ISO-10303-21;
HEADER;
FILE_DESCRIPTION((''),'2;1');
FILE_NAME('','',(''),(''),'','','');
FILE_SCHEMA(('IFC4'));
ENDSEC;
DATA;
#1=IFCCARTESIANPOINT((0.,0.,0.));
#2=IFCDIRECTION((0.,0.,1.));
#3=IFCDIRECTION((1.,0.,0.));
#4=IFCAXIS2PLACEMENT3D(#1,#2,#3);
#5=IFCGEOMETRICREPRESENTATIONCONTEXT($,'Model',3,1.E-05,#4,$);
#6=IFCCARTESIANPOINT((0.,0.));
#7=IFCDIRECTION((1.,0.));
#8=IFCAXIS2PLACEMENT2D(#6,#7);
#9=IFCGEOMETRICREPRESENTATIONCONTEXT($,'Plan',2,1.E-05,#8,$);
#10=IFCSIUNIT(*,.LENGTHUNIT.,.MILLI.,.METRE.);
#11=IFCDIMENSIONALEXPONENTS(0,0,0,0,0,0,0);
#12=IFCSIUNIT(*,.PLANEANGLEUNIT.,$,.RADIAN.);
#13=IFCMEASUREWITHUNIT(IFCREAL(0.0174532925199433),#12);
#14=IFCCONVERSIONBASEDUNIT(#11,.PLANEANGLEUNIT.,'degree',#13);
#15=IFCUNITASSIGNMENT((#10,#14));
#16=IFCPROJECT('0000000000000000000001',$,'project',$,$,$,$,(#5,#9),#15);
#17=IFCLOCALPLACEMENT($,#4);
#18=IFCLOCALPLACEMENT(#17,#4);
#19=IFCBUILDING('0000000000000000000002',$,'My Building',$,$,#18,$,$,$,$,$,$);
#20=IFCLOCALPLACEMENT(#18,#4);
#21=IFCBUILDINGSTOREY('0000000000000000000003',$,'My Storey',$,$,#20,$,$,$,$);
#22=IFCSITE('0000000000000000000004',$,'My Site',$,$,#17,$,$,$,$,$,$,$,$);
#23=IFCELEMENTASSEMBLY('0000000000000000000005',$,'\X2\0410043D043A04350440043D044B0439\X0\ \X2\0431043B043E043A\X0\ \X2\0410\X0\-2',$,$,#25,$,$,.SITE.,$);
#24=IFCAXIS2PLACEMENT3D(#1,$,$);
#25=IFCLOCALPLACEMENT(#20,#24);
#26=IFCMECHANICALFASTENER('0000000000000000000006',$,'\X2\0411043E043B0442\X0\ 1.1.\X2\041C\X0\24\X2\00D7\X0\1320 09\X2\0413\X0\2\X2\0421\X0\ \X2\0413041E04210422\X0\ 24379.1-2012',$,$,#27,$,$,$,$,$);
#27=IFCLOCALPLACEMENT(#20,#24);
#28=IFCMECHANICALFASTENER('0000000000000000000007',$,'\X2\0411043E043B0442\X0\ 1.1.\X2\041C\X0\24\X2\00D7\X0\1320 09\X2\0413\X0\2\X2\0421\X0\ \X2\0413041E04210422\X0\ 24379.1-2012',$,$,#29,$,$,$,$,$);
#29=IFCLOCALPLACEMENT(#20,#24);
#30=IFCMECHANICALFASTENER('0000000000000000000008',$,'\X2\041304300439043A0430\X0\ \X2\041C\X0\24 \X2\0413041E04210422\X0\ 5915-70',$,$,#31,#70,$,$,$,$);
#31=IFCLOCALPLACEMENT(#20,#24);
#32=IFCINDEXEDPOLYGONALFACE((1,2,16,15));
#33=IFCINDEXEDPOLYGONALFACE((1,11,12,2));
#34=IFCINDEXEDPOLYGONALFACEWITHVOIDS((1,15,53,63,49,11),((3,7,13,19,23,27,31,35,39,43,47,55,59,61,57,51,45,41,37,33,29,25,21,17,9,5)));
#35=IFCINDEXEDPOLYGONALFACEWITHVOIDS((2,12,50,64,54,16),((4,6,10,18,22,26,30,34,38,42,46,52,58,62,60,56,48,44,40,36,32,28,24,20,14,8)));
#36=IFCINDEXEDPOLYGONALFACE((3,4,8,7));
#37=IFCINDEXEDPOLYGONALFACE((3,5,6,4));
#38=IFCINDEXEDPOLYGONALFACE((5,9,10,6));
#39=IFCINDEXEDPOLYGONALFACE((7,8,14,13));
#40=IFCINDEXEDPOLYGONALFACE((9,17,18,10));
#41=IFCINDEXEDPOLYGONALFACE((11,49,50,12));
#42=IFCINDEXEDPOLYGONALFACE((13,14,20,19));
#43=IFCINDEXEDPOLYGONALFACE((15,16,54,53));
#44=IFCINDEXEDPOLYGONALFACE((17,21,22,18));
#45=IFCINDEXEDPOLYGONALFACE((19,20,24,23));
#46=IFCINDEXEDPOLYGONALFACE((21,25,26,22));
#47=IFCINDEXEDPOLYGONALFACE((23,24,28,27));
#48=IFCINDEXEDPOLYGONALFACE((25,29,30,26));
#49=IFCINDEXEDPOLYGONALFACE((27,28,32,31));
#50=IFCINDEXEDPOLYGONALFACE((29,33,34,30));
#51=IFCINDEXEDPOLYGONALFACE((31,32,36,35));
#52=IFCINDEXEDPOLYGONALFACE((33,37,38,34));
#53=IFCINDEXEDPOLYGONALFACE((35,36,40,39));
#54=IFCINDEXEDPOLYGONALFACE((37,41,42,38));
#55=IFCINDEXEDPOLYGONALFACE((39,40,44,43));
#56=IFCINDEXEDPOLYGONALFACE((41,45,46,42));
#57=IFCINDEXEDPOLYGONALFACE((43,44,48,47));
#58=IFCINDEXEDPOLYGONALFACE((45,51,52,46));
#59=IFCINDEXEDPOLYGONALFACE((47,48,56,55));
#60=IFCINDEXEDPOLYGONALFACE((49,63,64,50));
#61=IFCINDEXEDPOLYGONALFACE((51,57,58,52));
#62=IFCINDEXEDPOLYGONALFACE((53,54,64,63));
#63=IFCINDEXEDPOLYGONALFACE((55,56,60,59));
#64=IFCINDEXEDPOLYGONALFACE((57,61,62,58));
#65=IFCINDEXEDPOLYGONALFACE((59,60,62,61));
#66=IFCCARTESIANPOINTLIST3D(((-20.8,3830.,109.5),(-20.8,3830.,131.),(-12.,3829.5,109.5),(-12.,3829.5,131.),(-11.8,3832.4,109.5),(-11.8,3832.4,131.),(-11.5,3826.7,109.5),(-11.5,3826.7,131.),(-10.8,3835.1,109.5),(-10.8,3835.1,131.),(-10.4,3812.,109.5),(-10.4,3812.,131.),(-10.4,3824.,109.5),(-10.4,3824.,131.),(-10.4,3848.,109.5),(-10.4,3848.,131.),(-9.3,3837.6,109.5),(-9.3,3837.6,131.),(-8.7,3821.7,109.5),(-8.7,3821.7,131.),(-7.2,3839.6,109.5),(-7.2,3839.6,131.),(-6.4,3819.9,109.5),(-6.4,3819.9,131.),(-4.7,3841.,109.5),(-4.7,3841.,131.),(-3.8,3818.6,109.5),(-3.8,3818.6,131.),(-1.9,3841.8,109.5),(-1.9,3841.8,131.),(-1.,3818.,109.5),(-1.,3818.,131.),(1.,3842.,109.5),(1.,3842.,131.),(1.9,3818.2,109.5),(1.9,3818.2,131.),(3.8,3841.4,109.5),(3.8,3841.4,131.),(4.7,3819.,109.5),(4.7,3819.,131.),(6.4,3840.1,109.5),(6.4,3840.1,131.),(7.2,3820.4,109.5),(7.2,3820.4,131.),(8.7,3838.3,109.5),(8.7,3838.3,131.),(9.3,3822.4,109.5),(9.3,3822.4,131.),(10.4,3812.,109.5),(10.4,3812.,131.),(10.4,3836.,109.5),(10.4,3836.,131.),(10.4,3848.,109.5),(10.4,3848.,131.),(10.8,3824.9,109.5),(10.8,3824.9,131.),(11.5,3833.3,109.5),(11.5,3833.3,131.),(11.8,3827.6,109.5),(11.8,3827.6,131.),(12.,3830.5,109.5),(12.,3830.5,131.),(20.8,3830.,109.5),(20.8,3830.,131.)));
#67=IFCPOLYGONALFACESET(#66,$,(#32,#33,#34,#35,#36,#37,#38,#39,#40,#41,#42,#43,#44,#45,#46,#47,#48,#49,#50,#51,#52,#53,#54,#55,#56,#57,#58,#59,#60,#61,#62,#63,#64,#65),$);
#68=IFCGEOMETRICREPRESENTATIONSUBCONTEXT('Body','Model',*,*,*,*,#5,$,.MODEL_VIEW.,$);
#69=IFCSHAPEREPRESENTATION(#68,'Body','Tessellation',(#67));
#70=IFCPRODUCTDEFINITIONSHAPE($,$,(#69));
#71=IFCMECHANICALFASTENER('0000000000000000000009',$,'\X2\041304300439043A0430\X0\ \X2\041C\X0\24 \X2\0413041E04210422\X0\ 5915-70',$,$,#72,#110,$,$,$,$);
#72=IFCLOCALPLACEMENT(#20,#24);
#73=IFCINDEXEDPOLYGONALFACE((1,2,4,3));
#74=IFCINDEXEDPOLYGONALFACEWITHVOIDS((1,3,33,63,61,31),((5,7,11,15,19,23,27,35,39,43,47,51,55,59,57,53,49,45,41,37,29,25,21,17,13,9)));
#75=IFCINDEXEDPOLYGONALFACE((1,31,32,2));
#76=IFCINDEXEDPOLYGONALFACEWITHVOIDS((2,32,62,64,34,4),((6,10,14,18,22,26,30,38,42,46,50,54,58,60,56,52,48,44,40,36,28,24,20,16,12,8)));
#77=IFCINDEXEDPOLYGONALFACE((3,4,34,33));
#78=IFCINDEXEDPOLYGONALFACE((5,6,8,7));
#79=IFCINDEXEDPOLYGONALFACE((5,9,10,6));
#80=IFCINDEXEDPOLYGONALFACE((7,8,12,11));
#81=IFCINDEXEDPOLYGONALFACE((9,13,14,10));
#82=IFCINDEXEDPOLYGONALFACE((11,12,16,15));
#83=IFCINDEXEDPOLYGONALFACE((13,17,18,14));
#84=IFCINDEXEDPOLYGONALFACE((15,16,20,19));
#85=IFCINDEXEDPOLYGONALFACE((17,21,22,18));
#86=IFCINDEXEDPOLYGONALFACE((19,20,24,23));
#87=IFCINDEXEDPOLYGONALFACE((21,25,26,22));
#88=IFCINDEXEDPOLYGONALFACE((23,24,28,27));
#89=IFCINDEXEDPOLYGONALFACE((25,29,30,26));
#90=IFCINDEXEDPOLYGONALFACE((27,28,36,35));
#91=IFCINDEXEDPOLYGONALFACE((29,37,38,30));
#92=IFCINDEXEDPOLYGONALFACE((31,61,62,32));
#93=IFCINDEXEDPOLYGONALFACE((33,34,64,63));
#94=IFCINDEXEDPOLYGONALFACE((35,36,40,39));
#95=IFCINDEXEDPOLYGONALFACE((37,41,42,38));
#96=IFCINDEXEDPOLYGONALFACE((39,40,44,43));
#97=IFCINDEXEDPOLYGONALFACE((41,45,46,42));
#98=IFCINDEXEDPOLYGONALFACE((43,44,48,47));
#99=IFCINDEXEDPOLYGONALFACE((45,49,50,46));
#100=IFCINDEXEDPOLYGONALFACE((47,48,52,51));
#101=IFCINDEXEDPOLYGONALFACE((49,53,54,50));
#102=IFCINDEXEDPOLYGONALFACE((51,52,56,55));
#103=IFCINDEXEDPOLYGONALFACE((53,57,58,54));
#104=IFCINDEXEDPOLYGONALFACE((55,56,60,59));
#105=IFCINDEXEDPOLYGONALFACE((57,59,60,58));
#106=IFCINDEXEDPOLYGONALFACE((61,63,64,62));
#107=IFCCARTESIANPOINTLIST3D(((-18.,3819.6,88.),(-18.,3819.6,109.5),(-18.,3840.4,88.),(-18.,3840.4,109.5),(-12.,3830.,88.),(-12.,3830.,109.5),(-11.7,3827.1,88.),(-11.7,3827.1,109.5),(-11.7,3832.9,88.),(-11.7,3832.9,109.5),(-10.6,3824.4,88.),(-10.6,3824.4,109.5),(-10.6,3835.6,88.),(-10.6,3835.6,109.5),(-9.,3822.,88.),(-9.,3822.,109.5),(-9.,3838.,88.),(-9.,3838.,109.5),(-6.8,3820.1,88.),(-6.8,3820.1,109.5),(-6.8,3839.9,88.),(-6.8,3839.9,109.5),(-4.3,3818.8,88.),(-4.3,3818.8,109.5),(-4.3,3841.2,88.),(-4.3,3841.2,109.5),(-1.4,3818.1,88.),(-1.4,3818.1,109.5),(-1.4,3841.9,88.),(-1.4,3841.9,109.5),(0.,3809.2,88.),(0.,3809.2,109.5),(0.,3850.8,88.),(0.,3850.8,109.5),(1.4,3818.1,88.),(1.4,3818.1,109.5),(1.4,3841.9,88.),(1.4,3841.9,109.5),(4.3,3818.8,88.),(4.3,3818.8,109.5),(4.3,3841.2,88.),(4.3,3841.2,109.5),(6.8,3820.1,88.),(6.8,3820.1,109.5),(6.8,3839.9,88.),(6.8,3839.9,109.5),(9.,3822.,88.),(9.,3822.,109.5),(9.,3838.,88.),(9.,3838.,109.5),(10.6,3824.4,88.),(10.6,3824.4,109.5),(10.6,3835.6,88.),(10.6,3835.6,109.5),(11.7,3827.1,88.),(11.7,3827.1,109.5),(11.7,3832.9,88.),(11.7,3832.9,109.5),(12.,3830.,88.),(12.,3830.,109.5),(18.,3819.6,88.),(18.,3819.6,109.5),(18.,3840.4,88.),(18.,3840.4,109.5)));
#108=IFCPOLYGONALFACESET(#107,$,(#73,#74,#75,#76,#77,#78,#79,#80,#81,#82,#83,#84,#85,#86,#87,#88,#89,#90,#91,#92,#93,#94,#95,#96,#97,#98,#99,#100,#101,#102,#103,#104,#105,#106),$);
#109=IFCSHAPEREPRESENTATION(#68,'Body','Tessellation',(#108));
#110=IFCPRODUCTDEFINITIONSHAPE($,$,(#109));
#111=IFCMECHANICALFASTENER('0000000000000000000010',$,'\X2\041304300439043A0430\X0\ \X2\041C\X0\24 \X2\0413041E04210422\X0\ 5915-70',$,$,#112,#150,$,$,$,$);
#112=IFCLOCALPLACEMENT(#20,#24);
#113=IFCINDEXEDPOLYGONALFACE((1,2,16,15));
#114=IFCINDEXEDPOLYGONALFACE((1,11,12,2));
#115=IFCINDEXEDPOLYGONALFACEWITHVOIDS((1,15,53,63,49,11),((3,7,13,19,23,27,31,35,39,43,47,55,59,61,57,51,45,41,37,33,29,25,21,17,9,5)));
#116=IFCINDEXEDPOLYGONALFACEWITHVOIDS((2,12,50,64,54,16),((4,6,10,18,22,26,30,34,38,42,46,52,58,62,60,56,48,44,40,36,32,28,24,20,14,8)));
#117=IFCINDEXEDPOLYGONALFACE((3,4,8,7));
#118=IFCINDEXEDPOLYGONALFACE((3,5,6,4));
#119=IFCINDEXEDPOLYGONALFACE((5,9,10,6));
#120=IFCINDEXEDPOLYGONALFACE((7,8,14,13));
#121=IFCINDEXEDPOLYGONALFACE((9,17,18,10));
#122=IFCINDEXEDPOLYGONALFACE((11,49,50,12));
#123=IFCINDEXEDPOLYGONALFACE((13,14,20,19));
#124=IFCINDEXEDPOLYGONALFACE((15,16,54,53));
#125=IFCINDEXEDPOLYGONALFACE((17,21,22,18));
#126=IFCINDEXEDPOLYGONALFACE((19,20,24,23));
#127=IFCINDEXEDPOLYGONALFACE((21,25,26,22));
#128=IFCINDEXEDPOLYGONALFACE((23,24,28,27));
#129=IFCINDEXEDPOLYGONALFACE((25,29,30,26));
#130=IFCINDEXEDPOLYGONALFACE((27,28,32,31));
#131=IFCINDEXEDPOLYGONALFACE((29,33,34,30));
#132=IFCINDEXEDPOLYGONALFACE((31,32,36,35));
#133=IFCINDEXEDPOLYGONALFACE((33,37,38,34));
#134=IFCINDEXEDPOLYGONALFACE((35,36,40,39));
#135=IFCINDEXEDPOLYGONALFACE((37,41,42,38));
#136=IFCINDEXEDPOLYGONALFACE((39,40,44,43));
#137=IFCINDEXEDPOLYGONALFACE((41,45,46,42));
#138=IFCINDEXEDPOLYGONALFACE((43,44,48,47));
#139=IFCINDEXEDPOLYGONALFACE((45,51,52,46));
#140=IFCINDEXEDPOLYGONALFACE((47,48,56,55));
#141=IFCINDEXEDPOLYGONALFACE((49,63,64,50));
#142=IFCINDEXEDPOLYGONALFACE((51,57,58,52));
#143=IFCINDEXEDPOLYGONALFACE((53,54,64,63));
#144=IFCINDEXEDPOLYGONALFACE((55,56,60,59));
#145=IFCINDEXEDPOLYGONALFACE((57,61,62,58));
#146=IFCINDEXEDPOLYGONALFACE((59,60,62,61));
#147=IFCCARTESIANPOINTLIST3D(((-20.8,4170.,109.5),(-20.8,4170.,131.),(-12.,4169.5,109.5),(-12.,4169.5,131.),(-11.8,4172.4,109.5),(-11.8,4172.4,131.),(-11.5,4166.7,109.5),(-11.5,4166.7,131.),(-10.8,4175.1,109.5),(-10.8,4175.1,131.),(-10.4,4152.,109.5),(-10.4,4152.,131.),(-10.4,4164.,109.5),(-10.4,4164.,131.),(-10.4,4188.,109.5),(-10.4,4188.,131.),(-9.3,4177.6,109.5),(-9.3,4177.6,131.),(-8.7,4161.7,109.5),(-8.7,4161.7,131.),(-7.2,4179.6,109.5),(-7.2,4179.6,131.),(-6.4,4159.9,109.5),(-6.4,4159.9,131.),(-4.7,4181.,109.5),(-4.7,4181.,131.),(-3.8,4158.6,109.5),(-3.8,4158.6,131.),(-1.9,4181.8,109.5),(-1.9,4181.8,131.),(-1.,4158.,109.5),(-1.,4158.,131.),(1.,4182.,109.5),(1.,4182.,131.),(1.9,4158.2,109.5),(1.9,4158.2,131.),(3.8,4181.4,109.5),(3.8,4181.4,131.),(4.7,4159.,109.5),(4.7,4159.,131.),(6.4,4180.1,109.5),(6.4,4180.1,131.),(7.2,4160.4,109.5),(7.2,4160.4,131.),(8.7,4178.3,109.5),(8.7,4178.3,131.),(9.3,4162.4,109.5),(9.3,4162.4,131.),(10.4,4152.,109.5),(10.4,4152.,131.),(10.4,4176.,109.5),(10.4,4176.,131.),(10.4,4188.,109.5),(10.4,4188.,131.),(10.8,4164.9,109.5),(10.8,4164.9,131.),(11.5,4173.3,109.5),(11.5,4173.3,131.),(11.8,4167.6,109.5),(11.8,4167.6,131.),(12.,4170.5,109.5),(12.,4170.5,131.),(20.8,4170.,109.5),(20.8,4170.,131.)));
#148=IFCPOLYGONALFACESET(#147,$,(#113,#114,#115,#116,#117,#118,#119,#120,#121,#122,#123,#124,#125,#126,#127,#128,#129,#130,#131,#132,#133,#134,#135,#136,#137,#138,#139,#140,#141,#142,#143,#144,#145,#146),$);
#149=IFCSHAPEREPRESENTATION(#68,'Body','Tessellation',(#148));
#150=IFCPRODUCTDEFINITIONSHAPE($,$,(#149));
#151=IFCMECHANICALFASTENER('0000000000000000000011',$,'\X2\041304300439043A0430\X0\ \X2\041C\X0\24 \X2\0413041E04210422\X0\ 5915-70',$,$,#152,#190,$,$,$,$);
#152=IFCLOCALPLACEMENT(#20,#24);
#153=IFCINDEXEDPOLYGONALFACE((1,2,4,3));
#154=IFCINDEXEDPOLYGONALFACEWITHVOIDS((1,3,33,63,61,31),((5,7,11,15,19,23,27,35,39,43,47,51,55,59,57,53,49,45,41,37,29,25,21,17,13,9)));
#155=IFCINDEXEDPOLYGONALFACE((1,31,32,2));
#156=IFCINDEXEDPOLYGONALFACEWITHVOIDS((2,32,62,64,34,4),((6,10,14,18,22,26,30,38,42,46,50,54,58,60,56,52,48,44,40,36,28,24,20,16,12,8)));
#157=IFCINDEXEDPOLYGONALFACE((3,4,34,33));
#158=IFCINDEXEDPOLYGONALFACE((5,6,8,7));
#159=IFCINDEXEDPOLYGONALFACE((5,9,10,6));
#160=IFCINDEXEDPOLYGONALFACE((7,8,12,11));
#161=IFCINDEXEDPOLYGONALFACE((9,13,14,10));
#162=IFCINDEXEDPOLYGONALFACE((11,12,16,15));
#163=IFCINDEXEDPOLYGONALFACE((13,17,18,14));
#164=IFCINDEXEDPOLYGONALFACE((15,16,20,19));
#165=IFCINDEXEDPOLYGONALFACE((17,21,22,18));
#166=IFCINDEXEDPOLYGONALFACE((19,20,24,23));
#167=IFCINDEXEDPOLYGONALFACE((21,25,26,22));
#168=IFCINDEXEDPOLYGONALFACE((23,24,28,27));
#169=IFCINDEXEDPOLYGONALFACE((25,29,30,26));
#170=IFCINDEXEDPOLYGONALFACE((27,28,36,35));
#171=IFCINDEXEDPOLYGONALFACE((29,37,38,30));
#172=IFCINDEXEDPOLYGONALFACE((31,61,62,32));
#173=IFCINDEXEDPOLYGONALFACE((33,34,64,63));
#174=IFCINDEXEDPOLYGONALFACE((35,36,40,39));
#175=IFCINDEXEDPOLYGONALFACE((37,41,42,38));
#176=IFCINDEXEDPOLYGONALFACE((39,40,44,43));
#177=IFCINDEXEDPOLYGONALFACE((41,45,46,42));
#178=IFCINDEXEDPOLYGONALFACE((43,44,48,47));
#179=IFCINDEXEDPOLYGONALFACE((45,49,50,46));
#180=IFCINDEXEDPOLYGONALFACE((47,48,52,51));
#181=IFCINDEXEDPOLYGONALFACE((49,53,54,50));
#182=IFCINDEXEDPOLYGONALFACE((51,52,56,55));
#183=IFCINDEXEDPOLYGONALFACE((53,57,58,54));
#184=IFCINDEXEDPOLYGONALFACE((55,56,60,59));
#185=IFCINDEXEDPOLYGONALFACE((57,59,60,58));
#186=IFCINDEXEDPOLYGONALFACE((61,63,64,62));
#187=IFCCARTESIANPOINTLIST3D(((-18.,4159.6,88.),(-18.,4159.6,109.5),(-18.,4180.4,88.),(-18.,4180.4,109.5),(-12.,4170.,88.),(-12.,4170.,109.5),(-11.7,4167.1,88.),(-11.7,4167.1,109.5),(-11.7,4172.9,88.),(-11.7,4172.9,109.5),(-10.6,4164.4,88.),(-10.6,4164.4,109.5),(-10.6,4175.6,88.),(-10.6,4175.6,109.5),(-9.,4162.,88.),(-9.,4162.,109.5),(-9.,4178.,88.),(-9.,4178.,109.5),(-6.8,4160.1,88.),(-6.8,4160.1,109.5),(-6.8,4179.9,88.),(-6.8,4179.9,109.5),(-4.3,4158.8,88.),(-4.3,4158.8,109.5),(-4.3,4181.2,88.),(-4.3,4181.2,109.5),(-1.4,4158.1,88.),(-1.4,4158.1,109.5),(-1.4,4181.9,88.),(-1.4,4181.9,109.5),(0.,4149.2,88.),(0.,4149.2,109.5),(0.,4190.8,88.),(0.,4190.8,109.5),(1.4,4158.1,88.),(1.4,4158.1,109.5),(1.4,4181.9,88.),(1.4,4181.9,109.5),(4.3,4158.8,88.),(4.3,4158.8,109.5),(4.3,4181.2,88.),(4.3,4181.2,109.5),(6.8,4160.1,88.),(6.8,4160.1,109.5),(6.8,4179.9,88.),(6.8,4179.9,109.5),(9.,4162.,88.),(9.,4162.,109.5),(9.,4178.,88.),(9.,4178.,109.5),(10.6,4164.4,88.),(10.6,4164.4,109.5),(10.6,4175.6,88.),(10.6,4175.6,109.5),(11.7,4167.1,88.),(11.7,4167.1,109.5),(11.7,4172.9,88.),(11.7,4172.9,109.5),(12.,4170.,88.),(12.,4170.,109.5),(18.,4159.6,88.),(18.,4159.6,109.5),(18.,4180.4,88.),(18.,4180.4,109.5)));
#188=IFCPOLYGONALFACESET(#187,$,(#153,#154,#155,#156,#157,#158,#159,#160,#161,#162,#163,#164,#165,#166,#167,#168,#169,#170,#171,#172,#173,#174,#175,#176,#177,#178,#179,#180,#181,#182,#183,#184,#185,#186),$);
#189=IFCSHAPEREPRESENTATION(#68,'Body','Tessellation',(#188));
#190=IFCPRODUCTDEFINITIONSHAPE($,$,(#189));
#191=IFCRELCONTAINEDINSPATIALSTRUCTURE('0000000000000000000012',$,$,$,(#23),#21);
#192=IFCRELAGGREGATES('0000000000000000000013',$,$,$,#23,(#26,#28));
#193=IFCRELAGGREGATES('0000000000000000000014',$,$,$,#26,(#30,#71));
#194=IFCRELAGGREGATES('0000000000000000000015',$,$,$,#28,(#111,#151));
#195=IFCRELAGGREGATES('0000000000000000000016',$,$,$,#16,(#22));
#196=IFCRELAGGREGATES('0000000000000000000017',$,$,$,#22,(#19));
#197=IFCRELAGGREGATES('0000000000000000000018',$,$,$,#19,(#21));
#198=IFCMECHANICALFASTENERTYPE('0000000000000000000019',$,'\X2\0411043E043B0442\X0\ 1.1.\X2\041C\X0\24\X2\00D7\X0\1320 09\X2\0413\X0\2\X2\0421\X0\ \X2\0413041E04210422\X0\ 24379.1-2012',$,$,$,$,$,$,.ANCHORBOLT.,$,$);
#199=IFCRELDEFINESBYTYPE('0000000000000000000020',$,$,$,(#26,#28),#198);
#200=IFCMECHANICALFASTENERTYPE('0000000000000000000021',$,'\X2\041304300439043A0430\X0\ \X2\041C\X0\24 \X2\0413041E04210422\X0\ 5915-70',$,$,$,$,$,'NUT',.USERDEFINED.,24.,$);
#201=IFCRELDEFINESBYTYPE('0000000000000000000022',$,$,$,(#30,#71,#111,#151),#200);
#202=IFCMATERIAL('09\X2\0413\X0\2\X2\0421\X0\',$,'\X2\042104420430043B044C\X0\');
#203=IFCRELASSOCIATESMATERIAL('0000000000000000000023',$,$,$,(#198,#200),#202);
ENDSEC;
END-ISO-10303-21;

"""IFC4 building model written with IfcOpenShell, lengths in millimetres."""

from ifc_helpers import new_model, entity, si_unit, converted_unit, frame, origin_with_axes, origin_2d_with_axis, place, context, subcontext, project, spatial, polyline, outline, extrude, source, transform, mapped, material, type_object, type_shapes, element, aggregate, save


model = new_model("IFC4")

# Units and contexts
model_context = context("Model", 3, precision=1e-05, world=origin_with_axes())
plan_context = context("Plan", 2, precision=1e-05, world=origin_2d_with_axis())
body_context = subcontext(model_context, "Body", "Model", "MODEL_VIEW")
ifc_project = project(units=[si_unit("LENGTHUNIT", "METRE", prefix="MILLI"), converted_unit("PLANEANGLEUNIT", "degree", entity("IfcReal", 0.0174532925199433), si_unit("PLANEANGLEUNIT", "RADIAN"), dimensions=[0, 0, 0, 0, 0, 0, 0])], contexts=[model_context, plan_context])

# Site, building, storey
site_placement = place(None, origin_with_axes())
site = spatial("IfcSite", under=ifc_project, at=site_placement, Name="My Site")
building_placement = place(site_placement, origin_with_axes())
building = spatial("IfcBuilding", under=site, at=building_placement, Name="My Building")
storey_placement = place(building_placement, origin_with_axes())
storey = spatial("IfcBuildingStorey", under=building, at=storey_placement, Name="My Storey")

# Shared definitions
placement = place(storey_placement, frame((0.0, 4000.0, 0.0), z_axis=(0.0, 0.0, 1.0), x_axis=(1.0, 0.0, 0.0)))

# Element assembly, mechanical fasteners
assembly_1 = element("IfcElementAssembly", 1, at=placement, inside=storey, Name="Анкерный блок А-2", AssemblyPlace="SITE")
ifc_material_1 = material(Name="09Г2С", Category="Сталь")
mechanical_fastener_type_1 = type_object("IfcMechanicalFastenerType", Name="Болт 1.1.М24×1320 09Г2С ГОСТ 24379.1-2012", PredefinedType="ANCHORBOLT", material=ifc_material_1)
mechanical_fastener_1_placement = place(placement, frame((0.0, -170.0, 0.0), z_axis=(0.0, 0.0, 1.0), x_axis=(1.0, 0.0, 0.0)))
mechanical_fastener_1 = element("IfcMechanicalFastener", 2, at=mechanical_fastener_1_placement, type_object=mechanical_fastener_type_1, Name="Болт 1.1.М24×1320 09Г2С ГОСТ 24379.1-2012")
mechanical_fastener_2_placement = place(placement, frame((0.0, 170.0, 0.0), z_axis=(0.0, 0.0, 1.0), x_axis=(-1.0, 0.0, 0.0)))
mechanical_fastener_2 = element("IfcMechanicalFastener", 3, at=mechanical_fastener_2_placement, type_object=mechanical_fastener_type_1, Name="Болт 1.1.М24×1320 09Г2С ГОСТ 24379.1-2012")
aggregate(assembly_1, [mechanical_fastener_1, mechanical_fastener_2])

# Mechanical fasteners
mechanical_fastener_type_2 = type_object("IfcMechanicalFastenerType", Name="Гайка М24 ГОСТ 5915-70", ElementType="NUT", NominalDiameter=24.0, PredefinedType="USERDEFINED", material=ifc_material_1)
shared_shape_1 = source(origin_with_axes(), body_context, "Body", "SweptSolid", [
    extrude(outline(polyline([(-10.4, -18.0), (10.4, -18.0), (20.8, 0.0), (10.4, 18.0), (-10.4, 18.0), (-20.8, 0.0), (-10.4, -18.0)]), holes=[polyline([(-8.0, 9.0), (-5.6, 10.6), (-2.9, 11.7), (0.0, 12.0), (2.9, 11.7), (5.6, 10.6), (8.0, 9.0), (9.9, 6.8), (11.2, 4.3), (11.9, 1.4), (11.9, -1.4), (11.2, -4.3), (9.9, -6.8), (8.0, -9.0), (5.6, -10.6), (2.9, -11.7), (0.0, -12.0), (-2.9, -11.7), (-5.6, -10.6), (-8.0, -9.0), (-9.9, -6.8), (-11.2, -4.3), (-11.9, -1.4), (-11.9, 1.4), (-11.2, 4.3), (-9.9, 6.8), (-8.0, 9.0)])]), frame((0.0, 0.0, 0.0), z_axis=(0.0, 0.0, 1.0), x_axis=(0.0, 1.0, 0.0)), (0.0, 0.0, 1.0), 21.5),
])
type_shapes(mechanical_fastener_type_2, [shared_shape_1])
mechanical_fastener_3_placement = place(mechanical_fastener_1_placement, frame((0.0, 0.0, 109.5), z_axis=(0.0, 0.0, 1.0), x_axis=(0.866025, 0.5, 0.0)))
mechanical_fastener_3 = element("IfcMechanicalFastener", 4, at=mechanical_fastener_3_placement, type_object=mechanical_fastener_type_2, Name="Гайка М24 ГОСТ 5915-70", context=body_context, shape_type="MappedRepresentation", body=[
    mapped(shared_shape_1, transform((0.0, 0.0, 0.0), x_axis=(1.0, 0.0, 0.0), y_axis=(0.0, 1.0, 0.0), z_axis=(0.0, 0.0, 1.0), scale=1.0)),
])
mechanical_fastener_4_placement = place(mechanical_fastener_1_placement, frame((0.0, 0.0, 88.0), z_axis=(0.0, 0.0, 1.0), x_axis=(1.0, 0.0, 0.0)))
mechanical_fastener_4 = element("IfcMechanicalFastener", 5, at=mechanical_fastener_4_placement, type_object=mechanical_fastener_type_2, Name="Гайка М24 ГОСТ 5915-70", context=body_context, shape_type="MappedRepresentation", body=[
    mapped(shared_shape_1, transform((0.0, 0.0, 0.0), x_axis=(1.0, 0.0, 0.0), y_axis=(0.0, 1.0, 0.0), z_axis=(0.0, 0.0, 1.0), scale=1.0)),
])
mechanical_fastener_5_placement = place(mechanical_fastener_2_placement, frame((0.0, 0.0, 109.5), z_axis=(0.0, 0.0, 1.0), x_axis=(0.866025, 0.5, 0.0)))
mechanical_fastener_5 = element("IfcMechanicalFastener", 6, at=mechanical_fastener_5_placement, type_object=mechanical_fastener_type_2, Name="Гайка М24 ГОСТ 5915-70", context=body_context, shape_type="MappedRepresentation", body=[
    mapped(shared_shape_1, transform((0.0, 0.0, 0.0), x_axis=(1.0, 0.0, 0.0), y_axis=(0.0, 1.0, 0.0), z_axis=(0.0, 0.0, 1.0), scale=1.0)),
])
mechanical_fastener_6_placement = place(mechanical_fastener_2_placement, frame((0.0, 0.0, 88.0), z_axis=(0.0, 0.0, 1.0), x_axis=(1.0, 0.0, 0.0)))
mechanical_fastener_6 = element("IfcMechanicalFastener", 7, at=mechanical_fastener_6_placement, type_object=mechanical_fastener_type_2, Name="Гайка М24 ГОСТ 5915-70", context=body_context, shape_type="MappedRepresentation", body=[
    mapped(shared_shape_1, transform((0.0, 0.0, 0.0), x_axis=(1.0, 0.0, 0.0), y_axis=(0.0, 1.0, 0.0), z_axis=(0.0, 0.0, 1.0), scale=1.0)),
])
aggregate(mechanical_fastener_1, [mechanical_fastener_3, mechanical_fastener_4])
aggregate(mechanical_fastener_2, [mechanical_fastener_5, mechanical_fastener_6])

save(model, "model.ifc")
